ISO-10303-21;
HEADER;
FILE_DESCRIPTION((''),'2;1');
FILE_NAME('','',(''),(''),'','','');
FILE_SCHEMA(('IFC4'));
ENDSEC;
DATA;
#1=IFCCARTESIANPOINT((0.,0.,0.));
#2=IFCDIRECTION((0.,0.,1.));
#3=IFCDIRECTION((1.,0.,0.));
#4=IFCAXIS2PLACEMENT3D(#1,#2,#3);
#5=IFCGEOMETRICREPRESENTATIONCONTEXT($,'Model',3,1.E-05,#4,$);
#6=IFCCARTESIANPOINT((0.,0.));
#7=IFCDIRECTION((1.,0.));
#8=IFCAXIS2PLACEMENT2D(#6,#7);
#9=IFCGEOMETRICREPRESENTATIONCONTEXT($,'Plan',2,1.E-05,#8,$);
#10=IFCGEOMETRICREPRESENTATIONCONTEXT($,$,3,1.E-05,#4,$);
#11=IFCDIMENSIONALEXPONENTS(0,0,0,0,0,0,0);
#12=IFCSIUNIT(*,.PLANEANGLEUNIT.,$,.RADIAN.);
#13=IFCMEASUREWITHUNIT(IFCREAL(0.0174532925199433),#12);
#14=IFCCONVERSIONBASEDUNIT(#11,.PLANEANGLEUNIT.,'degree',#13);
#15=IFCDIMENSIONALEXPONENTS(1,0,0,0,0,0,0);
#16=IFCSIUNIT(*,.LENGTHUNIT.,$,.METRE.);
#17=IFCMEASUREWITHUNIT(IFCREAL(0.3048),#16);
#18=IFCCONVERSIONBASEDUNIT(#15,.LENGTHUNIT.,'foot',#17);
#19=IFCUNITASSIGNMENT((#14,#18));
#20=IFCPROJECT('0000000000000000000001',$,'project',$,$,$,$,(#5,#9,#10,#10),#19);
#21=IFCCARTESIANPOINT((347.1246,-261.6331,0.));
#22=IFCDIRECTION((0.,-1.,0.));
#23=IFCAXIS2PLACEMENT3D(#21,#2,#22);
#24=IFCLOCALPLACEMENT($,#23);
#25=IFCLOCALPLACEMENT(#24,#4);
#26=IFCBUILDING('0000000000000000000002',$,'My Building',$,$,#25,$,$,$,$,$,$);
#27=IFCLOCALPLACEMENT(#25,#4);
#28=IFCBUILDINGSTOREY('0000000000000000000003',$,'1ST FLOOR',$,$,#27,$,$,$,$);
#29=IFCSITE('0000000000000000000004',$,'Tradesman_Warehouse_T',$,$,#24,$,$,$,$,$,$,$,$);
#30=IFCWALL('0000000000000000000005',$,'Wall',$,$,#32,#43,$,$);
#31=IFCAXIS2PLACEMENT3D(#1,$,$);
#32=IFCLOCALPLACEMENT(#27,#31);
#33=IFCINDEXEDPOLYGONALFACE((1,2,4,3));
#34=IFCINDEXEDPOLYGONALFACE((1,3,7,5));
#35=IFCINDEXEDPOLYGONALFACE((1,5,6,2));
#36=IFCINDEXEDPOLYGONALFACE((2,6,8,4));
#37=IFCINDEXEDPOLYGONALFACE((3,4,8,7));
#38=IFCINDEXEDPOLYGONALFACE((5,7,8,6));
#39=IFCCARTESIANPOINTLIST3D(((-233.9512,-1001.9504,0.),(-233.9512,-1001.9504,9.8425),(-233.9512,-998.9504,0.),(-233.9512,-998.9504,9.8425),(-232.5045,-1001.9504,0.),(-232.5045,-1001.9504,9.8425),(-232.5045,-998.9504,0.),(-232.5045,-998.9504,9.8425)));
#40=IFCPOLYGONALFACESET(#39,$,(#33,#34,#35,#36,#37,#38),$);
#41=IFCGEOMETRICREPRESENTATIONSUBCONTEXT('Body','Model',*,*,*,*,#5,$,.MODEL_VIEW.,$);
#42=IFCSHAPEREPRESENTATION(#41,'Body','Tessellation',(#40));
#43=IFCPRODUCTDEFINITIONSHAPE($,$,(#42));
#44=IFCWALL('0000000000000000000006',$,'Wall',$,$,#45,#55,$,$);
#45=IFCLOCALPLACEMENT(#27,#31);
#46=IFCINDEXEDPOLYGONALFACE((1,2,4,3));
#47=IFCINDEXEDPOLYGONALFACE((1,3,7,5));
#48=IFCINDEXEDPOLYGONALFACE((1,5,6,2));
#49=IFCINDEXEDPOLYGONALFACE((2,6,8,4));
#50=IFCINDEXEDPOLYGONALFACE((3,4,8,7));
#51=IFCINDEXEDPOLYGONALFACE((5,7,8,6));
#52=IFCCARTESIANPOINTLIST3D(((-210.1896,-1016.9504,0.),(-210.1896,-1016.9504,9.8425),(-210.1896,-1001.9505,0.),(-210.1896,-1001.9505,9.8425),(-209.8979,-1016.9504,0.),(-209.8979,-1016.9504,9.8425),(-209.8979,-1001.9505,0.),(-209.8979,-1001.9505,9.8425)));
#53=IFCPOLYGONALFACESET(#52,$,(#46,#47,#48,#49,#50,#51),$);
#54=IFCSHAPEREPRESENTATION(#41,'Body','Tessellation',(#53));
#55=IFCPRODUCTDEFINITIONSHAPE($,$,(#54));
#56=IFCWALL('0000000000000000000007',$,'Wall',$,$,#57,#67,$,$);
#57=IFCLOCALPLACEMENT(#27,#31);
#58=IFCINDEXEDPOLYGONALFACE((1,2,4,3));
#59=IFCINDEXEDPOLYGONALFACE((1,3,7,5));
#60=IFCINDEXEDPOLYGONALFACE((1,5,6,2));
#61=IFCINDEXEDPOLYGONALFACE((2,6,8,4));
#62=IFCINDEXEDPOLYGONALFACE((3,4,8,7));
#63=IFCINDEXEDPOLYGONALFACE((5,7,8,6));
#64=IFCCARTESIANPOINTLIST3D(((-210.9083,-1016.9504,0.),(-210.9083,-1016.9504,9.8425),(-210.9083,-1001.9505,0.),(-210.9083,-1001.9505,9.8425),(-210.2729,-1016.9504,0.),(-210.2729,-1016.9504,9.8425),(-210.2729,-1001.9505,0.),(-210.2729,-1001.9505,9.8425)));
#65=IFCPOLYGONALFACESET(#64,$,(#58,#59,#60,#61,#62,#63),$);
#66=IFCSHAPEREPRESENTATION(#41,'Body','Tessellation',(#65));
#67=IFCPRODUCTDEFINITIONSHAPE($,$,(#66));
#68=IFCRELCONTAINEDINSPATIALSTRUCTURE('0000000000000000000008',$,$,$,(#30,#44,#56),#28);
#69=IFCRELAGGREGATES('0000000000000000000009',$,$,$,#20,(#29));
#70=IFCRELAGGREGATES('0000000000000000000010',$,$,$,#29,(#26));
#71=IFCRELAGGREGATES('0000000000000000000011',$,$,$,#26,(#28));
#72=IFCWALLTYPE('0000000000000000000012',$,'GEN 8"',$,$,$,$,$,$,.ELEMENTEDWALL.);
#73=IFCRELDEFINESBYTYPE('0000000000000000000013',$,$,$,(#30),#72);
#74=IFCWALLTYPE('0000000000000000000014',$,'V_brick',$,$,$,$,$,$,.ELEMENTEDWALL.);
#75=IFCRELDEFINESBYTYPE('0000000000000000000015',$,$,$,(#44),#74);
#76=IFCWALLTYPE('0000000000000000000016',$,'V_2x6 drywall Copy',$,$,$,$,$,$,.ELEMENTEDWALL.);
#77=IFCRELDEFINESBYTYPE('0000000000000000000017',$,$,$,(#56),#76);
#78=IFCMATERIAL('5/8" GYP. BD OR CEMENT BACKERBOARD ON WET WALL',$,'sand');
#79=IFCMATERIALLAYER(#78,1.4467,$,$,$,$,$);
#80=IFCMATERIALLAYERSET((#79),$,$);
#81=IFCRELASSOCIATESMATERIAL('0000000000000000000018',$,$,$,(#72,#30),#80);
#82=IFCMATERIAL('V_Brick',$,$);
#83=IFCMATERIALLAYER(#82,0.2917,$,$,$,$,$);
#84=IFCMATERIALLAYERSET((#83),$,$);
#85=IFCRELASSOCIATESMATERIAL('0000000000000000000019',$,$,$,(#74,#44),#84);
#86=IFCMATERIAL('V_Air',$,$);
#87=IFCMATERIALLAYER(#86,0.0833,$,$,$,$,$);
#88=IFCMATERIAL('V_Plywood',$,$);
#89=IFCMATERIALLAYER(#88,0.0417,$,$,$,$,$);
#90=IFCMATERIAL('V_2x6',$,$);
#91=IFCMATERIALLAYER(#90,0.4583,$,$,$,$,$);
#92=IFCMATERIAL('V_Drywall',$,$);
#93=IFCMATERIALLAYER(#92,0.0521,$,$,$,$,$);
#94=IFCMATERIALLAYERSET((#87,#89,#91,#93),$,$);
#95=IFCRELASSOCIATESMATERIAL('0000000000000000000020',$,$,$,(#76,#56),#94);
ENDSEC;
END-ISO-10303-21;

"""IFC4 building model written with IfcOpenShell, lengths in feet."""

from ifc_helpers import new_model, entity, si_unit, converted_unit, frame, origin_with_axes, origin_2d_with_axis, place, context, subcontext, project, spatial, indexed_curve, outline, extrude, material, layer, layer_set, layer_usage, type_object, element, save


model = new_model("IFC4")

# Units and contexts
model_context = context("Model", 3, precision=1e-05, world=origin_with_axes())
plan_context = context("Plan", 2, precision=1e-05, world=origin_2d_with_axis())
context_of_model = context(None, 3, precision=1e-05, world=origin_with_axes())
body_context = subcontext(model_context, "Body", "Model", "MODEL_VIEW")
ifc_project = project(units=[converted_unit("PLANEANGLEUNIT", "degree", entity("IfcReal", 0.0174532925199433), si_unit("PLANEANGLEUNIT", "RADIAN"), dimensions=[0, 0, 0, 0, 0, 0, 0]), converted_unit("LENGTHUNIT", "foot", entity("IfcReal", 0.3048), si_unit("LENGTHUNIT", "METRE"), dimensions=[1, 0, 0, 0, 0, 0, 0])], contexts=[model_context, plan_context, context_of_model, context_of_model])

# Site, building, storey
site_placement = place(None, frame((347.1246, -261.6331, 0.0), z_axis=(0.0, 0.0, 1.0), x_axis=(0.0, -1.0, 0.0)))
site = spatial("IfcSite", under=ifc_project, at=site_placement, Name="Tradesman_Warehouse_T")
building_placement = place(site_placement, frame((0.0, 0.0, 0.0), z_axis=(0.0, 0.0, 1.0), x_axis=(1.0, 0.0, 0.0)))
building = spatial("IfcBuilding", under=site, at=building_placement, Name="My Building")
storey_placement = place(building_placement, frame((0.0, 0.0, 0.0), z_axis=(0.0, 0.0, 1.0), x_axis=(1.0, 0.0, 0.0)))
storey = spatial("IfcBuildingStorey", under=building, at=storey_placement, Name="1ST FLOOR")

# Walls
ifc_material_1 = material(Name="5/8\" GYP. BD OR CEMENT BACKERBOARD ON WET WALL", Category="sand")
ifc_layer_1 = layer(ifc_material_1, 1.4467)
ifc_layer_set_1 = layer_set([ifc_layer_1])
ifc_layer_usage_1 = layer_usage(ifc_layer_set_1, "AXIS2", "POSITIVE", 0.0)
wall_type_1 = type_object("IfcWallType", Name="GEN 8\"", PredefinedType="ELEMENTEDWALL", material=ifc_layer_set_1)
wall_1_placement = place(storey_placement, frame((-232.5045, -1001.9504, 0.0), z_axis=(0.0, 0.0, 1.0), x_axis=(0.0, 1.0, 0.0)))
element("IfcWall", 1, at=wall_1_placement, inside=storey, type_object=wall_type_1, material=ifc_layer_usage_1, Name="Wall", context=body_context, shape_type="SweptSolid", body=[
    extrude(outline(indexed_curve([(0.0, 0.0), (0.0, 1.4467), (3.0, 1.4467), (3.0, 0.0), (0.0, 0.0)], self_intersect=False)), origin_with_axes(), (0.0, 0.0, 1.0), 9.8425),
])
ifc_material_2 = material(Name="V_Brick")
ifc_layer_2 = layer(ifc_material_2, 0.2917)
ifc_layer_set_2 = layer_set([ifc_layer_2])
ifc_layer_usage_2 = layer_usage(ifc_layer_set_2, "AXIS2", "POSITIVE", 0.0)
wall_type_2 = type_object("IfcWallType", Name="V_brick", PredefinedType="ELEMENTEDWALL", material=ifc_layer_set_2)
wall_2_placement = place(storey_placement, frame((-209.8979, -1016.9504, 0.0), z_axis=(0.0, 0.0, 1.0), x_axis=(0.0, 1.0, 0.0)))
element("IfcWall", 2, at=wall_2_placement, inside=storey, type_object=wall_type_2, material=ifc_layer_usage_2, Name="Wall", context=body_context, shape_type="SweptSolid", body=[
    extrude(outline(indexed_curve([(0.0, 0.0), (0.0, 0.2917), (14.9999, 0.2917), (14.9999, 0.0), (0.0, 0.0)], self_intersect=False)), origin_with_axes(), (0.0, 0.0, 1.0), 9.8425),
])
ifc_material_3 = material(Name="V_Air")
ifc_layer_3 = layer(ifc_material_3, 0.0833)
ifc_material_4 = material(Name="V_Plywood")
ifc_layer_4 = layer(ifc_material_4, 0.0417)
ifc_material_5 = material(Name="V_2x6")
ifc_layer_5 = layer(ifc_material_5, 0.4583)
ifc_material_6 = material(Name="V_Drywall")
ifc_layer_6 = layer(ifc_material_6, 0.0521)
ifc_layer_set_3 = layer_set([ifc_layer_3, ifc_layer_4, ifc_layer_5, ifc_layer_6])
ifc_layer_usage_3 = layer_usage(ifc_layer_set_3, "AXIS2", "POSITIVE", 0.0)
wall_type_3 = type_object("IfcWallType", Name="V_2x6 drywall Copy", PredefinedType="ELEMENTEDWALL", material=ifc_layer_set_3)
wall_3_placement = place(storey_placement, frame((-210.2729, -1016.9504, 0.0), z_axis=(0.0, 0.0, 1.0), x_axis=(0.0, 1.0, 0.0)))
element("IfcWall", 3, at=wall_3_placement, inside=storey, type_object=wall_type_3, material=ifc_layer_usage_3, Name="Wall", context=body_context, shape_type="SweptSolid", body=[
    extrude(outline(indexed_curve([(0.0, 0.0), (0.0, 0.6354), (14.9999, 0.6354), (14.9999, 0.0), (0.0, 0.0)], self_intersect=False)), origin_with_axes(), (0.0, 0.0, 1.0), 9.8425),
])

save(model, "model.ifc")
